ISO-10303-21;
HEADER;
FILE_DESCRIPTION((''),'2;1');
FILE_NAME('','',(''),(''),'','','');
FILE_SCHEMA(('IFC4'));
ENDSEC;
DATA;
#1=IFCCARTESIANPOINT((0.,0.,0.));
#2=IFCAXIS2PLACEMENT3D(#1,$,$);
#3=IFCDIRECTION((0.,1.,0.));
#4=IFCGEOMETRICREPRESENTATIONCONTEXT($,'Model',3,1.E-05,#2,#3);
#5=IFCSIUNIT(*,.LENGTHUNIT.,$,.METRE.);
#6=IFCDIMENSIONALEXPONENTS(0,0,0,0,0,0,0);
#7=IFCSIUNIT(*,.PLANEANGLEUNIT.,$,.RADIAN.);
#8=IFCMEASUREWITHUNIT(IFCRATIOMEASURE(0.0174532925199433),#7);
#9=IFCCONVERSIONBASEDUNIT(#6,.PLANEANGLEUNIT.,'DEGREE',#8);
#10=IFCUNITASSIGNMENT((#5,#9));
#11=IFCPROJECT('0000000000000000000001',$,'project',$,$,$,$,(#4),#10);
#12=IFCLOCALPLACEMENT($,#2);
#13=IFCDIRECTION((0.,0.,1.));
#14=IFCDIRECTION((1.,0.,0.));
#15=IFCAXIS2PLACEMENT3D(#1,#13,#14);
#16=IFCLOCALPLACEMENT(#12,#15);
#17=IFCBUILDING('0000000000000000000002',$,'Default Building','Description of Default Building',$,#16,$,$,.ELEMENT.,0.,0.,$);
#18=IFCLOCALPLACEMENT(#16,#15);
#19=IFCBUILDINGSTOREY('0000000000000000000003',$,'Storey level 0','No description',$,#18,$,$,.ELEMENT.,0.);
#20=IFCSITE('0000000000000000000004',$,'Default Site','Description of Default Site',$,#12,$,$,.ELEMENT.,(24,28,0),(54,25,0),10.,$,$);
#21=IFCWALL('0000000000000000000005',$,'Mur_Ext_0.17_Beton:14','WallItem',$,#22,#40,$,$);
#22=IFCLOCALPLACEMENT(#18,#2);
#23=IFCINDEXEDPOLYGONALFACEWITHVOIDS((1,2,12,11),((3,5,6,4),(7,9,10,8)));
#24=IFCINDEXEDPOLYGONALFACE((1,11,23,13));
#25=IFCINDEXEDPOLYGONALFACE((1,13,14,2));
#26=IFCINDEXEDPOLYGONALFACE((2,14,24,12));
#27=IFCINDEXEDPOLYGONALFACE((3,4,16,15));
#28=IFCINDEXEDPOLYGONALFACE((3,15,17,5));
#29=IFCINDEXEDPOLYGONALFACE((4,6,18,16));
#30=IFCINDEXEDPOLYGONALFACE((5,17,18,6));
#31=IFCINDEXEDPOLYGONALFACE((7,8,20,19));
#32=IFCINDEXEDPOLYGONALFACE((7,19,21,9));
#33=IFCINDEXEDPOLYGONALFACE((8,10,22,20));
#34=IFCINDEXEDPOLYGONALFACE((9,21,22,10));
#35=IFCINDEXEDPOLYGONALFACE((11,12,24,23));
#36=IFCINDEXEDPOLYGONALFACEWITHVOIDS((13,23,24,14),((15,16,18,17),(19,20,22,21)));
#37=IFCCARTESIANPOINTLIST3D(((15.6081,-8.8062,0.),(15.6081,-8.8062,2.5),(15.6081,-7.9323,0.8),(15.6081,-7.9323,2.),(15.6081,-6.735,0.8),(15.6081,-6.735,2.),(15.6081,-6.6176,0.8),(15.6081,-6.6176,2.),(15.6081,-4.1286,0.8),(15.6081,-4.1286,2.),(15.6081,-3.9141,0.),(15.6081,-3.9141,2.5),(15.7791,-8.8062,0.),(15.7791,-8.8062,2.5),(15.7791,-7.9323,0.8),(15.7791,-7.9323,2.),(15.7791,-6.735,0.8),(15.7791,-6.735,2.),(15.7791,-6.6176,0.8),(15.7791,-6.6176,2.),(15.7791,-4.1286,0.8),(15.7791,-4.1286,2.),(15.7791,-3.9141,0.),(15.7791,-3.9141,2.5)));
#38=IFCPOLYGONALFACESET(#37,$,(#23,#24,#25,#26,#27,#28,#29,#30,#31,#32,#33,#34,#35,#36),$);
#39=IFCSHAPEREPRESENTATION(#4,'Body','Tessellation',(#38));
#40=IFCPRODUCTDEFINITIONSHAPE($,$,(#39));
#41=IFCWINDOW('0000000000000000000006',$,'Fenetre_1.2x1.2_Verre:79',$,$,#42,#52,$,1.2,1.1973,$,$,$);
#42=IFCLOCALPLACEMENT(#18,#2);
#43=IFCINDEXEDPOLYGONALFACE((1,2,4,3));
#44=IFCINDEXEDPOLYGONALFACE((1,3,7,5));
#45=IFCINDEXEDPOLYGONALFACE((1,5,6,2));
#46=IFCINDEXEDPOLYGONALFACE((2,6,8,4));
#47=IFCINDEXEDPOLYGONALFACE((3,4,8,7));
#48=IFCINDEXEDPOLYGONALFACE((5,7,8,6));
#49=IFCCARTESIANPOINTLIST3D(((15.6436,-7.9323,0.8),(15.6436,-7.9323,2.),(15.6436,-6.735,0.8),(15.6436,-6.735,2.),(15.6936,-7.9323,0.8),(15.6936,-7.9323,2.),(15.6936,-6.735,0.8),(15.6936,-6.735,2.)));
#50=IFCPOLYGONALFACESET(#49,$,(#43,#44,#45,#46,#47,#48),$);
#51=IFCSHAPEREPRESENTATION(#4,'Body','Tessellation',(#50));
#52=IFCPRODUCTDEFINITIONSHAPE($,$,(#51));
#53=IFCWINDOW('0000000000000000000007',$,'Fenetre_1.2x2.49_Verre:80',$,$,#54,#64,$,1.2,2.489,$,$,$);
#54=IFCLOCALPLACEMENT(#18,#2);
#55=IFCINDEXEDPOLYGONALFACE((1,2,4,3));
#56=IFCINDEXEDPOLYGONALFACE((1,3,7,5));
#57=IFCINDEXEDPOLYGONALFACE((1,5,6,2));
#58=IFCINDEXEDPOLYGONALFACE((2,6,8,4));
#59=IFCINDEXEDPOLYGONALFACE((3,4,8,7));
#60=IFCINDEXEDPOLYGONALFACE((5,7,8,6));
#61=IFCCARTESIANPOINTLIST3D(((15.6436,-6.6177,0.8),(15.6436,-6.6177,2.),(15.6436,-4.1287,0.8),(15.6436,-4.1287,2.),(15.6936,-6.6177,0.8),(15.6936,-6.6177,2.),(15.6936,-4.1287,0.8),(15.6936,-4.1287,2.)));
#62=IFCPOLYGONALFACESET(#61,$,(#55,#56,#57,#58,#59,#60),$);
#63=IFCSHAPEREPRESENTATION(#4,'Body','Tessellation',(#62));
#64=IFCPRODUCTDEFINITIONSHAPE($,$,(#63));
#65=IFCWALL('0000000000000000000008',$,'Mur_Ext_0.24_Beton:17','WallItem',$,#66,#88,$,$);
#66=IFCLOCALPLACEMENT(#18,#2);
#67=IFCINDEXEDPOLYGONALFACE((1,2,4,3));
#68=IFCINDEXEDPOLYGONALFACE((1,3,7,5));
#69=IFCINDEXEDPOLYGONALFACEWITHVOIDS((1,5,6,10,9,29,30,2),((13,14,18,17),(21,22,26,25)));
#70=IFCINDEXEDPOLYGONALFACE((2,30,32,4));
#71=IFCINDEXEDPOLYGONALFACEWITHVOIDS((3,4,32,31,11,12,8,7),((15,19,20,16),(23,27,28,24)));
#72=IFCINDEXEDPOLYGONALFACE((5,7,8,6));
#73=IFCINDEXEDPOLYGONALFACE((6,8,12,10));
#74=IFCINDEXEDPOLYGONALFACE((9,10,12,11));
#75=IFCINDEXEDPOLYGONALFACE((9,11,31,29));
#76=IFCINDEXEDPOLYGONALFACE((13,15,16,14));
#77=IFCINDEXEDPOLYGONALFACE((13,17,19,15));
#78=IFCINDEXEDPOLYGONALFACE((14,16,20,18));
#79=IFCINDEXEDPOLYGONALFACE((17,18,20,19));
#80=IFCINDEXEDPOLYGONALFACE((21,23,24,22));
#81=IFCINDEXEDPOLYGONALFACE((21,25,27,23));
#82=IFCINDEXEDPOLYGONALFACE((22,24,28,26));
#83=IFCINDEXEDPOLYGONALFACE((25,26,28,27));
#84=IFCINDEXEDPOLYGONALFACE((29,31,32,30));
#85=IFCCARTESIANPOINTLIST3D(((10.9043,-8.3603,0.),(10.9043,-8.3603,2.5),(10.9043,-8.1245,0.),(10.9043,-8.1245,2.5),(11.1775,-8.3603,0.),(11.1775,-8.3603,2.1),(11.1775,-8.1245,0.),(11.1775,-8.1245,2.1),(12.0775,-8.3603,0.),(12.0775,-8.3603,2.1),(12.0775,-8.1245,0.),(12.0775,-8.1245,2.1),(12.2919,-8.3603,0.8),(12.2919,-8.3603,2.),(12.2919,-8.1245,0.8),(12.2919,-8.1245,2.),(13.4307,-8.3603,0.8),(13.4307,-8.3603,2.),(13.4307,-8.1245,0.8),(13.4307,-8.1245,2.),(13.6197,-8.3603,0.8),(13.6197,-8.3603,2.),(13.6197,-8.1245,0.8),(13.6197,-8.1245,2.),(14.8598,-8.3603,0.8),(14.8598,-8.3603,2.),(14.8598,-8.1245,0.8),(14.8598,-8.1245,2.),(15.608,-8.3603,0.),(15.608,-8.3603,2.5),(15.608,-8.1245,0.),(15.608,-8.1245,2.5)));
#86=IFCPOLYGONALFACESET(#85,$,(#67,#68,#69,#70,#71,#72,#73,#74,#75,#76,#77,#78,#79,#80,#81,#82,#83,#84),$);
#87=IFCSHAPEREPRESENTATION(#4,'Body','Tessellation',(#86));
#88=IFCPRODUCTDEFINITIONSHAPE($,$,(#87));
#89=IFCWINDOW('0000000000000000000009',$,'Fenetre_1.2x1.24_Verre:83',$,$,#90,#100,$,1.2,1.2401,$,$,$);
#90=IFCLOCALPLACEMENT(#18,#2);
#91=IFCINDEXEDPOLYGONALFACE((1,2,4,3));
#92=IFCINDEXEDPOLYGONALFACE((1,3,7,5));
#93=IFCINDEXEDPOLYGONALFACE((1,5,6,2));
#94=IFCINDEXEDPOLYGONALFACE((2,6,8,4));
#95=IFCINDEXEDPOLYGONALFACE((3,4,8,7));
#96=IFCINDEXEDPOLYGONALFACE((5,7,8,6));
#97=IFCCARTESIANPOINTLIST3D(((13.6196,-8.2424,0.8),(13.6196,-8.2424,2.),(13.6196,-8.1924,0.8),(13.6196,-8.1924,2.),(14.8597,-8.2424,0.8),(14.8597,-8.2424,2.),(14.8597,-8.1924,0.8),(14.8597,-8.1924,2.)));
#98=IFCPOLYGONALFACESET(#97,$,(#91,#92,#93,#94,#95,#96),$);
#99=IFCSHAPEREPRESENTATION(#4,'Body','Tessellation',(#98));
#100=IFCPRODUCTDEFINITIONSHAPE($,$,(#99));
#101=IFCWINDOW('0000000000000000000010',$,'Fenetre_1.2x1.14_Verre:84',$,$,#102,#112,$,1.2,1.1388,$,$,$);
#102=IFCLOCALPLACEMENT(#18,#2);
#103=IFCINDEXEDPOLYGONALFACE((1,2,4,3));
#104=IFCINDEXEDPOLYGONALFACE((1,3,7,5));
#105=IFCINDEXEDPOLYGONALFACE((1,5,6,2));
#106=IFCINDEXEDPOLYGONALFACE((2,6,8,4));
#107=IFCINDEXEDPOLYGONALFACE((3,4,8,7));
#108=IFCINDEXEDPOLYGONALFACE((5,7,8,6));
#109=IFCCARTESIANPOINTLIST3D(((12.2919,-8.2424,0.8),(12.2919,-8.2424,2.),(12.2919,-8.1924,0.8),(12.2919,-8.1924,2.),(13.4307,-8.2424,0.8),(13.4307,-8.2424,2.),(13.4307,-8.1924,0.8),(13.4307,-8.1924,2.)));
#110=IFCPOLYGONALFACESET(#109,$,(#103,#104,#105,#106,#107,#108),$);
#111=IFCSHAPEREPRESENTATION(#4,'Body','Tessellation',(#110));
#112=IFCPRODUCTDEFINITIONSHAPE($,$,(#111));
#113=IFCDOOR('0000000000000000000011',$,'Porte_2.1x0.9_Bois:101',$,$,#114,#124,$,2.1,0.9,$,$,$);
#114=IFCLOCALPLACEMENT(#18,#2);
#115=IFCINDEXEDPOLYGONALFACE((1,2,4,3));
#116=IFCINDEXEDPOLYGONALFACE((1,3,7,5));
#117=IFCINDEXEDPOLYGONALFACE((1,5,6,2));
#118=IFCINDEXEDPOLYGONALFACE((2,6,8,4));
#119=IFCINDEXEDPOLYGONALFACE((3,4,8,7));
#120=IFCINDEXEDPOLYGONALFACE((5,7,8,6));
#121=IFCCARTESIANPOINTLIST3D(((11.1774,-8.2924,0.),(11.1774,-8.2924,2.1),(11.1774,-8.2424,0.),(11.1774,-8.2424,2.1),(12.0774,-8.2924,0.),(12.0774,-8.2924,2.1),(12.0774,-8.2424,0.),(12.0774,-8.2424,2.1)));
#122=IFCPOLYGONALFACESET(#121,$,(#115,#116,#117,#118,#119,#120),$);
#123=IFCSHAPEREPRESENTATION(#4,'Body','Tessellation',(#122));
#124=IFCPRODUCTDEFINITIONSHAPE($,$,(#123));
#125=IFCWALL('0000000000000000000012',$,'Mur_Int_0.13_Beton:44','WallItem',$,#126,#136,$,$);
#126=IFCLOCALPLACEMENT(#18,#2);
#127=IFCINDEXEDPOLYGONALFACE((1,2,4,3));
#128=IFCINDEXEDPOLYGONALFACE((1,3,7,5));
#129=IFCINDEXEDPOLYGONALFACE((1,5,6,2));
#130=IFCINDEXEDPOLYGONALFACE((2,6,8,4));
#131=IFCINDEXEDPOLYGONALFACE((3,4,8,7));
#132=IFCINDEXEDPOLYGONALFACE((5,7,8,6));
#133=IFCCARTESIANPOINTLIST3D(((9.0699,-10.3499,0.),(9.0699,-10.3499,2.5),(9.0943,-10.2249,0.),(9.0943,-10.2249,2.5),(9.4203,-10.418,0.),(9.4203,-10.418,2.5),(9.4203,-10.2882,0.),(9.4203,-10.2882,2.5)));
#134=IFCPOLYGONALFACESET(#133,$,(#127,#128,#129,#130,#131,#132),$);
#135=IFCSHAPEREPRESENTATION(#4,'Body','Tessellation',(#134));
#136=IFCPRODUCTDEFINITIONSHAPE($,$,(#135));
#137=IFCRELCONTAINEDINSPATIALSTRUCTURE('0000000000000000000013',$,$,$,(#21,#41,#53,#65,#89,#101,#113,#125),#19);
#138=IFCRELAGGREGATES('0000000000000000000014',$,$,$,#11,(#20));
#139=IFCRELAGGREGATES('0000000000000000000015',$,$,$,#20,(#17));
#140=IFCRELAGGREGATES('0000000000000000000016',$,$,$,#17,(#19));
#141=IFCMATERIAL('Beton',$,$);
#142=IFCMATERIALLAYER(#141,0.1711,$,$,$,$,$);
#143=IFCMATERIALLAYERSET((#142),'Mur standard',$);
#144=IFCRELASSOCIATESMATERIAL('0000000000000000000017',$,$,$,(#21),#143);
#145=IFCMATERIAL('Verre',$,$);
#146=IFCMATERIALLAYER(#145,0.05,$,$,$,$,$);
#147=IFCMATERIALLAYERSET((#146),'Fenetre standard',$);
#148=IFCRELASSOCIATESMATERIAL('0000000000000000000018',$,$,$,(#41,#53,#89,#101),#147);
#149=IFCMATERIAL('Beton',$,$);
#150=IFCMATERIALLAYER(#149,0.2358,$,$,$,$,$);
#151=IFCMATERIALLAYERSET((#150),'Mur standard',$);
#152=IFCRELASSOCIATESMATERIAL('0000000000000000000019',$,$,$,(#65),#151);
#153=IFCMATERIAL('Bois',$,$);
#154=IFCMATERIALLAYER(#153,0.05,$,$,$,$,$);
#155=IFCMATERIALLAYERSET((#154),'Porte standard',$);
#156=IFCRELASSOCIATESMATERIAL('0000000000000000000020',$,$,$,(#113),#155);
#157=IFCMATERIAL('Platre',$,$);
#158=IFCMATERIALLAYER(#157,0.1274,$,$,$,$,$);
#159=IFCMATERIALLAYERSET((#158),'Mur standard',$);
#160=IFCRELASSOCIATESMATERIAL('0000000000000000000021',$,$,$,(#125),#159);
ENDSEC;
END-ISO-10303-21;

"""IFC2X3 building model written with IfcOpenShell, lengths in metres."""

from ifc_helpers import new_model, entity, si_unit, converted_unit, direction, frame, origin, origin_with_axes, place, context, project, spatial, polyline, outline, extrude, material, layer, layer_set, layer_usage, element, fill, save


model = new_model("IFC2X3")

# Units and contexts
model_context = context("Model", 3, precision=1e-05, world=origin(), true_north=direction((0.0, 1.0, 0.0)))
ifc_project = project(units=[si_unit("LENGTHUNIT", "METRE"), converted_unit("PLANEANGLEUNIT", "DEGREE", entity("IfcRatioMeasure", 0.0174532925199433), si_unit("PLANEANGLEUNIT", "RADIAN"), dimensions=[0, 0, 0, 0, 0, 0, 0])], contexts=[model_context])

# Site, building, storey
site_placement = place(None, origin())
site = spatial("IfcSite", under=ifc_project, at=site_placement, Name="Default Site", Description="Description of Default Site", CompositionType="ELEMENT", RefLatitude=(24, 28, 0), RefLongitude=(54, 25, 0), RefElevation=10.0)
building_placement = place(site_placement, origin_with_axes())
building = spatial("IfcBuilding", under=site, at=building_placement, Name="Default Building", Description="Description of Default Building", CompositionType="ELEMENT", ElevationOfRefHeight=0.0, ElevationOfTerrain=0.0)
storey_placement = place(building_placement, origin_with_axes())
storey = spatial("IfcBuildingStorey", under=building, at=storey_placement, Name="Storey level 0", Description="No description", CompositionType="ELEMENT", Elevation=0.0)

# Shared definitions
ifc_material_1 = material(Name="Verre")
ifc_layer_1 = layer(ifc_material_1, 0.05)
ifc_layer_set_1 = layer_set([ifc_layer_1], Name="Fenetre standard")
ifc_layer_usage_1 = layer_usage(ifc_layer_set_1, "AXIS2", "NEGATIVE", 0.05)
ifc_material_2 = material(Name="Bois")
ifc_layer_2 = layer(ifc_material_2, 0.05)
ifc_layer_set_2 = layer_set([ifc_layer_2], Name="Porte standard")
ifc_layer_usage_2 = layer_usage(ifc_layer_set_2, "AXIS2", "NEGATIVE", 0.05)

# Wall, openings, windows
ifc_material_3 = material(Name="Beton")
ifc_layer_3 = layer(ifc_material_3, 0.1711)
ifc_layer_set_3 = layer_set([ifc_layer_3], Name="Mur standard")
ifc_layer_usage_3 = layer_usage(ifc_layer_set_3, "AXIS2", "NEGATIVE", 0.1711)
wall_1_placement = place(storey_placement, frame((15.6936, -3.9141, 0.0), z_axis=(0.0, 0.0, 1.0), x_axis=(0.0, -1.0, 0.0)))
wall_1 = element("IfcWall", 1, at=wall_1_placement, inside=storey, material=ifc_layer_usage_3, Name="Mur_Ext_0.17_Beton:14", Description="WallItem", context=model_context, shape_type="SweptSolid", body=[
    extrude(outline(polyline([(0.0, -0.0855), (4.8921, -0.0855), (4.8921, 0.0855), (0.0, 0.0855), (0.0, -0.0855)])), origin(), (0.0, 0.0, 1.0), 2.5),
])
opening_1_placement = place(storey_placement, frame((15.6081, -6.735, 0.8), z_axis=(0.0, 0.0, 1.0), x_axis=(0.0, -1.0, 0.0)))
opening_1 = element("IfcOpeningElement", 2, at=opening_1_placement, cuts=wall_1, context=model_context, shape_type="SweptSolid", body=[
    extrude(outline(polyline([(0.0, -0.05), (1.1973, -0.05), (1.1973, 0.2211), (0.0, 0.2211), (0.0, -0.05)])), origin(), (0.0, 0.0, 1.0), 1.2),
])
opening_2_placement = place(storey_placement, frame((15.6081, -4.1286, 0.8), z_axis=(0.0, 0.0, 1.0), x_axis=(0.0, -1.0, 0.0)))
opening_2 = element("IfcOpeningElement", 3, at=opening_2_placement, cuts=wall_1, context=model_context, shape_type="SweptSolid", body=[
    extrude(outline(polyline([(0.0, -0.05), (2.489, -0.05), (2.489, 0.2211), (0.0, 0.2211), (0.0, -0.05)])), origin(), (0.0, 0.0, 1.0), 1.2),
])
window_1_placement = place(wall_1_placement, frame((2.8209, 0.0, 0.8), z_axis=(0.0, 0.0, 1.0), x_axis=(1.0, 0.0, 0.0)))
window_1 = element("IfcWindow", 4, at=window_1_placement, inside=storey, material=ifc_layer_usage_1, Name="Fenetre_1.2x1.2_Verre:79", OverallHeight=1.2, OverallWidth=1.1973, context=model_context, shape_type="SweptSolid", body=[
    extrude(outline(polyline([(0.0, 0.0), (1.1973, 0.0), (1.1973, -0.05), (0.0, -0.05), (0.0, 0.0)])), origin(), (0.0, 0.0, 1.0), 1.2),
])
fill(opening_1, window_1)
window_2_placement = place(wall_1_placement, frame((0.2146, 0.0, 0.8), z_axis=(0.0, 0.0, 1.0), x_axis=(1.0, 0.0, 0.0)))
window_2 = element("IfcWindow", 5, at=window_2_placement, inside=storey, material=ifc_layer_usage_1, Name="Fenetre_1.2x2.49_Verre:80", OverallHeight=1.2, OverallWidth=2.489, context=model_context, shape_type="SweptSolid", body=[
    extrude(outline(polyline([(0.0, 0.0), (2.489, 0.0), (2.489, -0.05), (0.0, -0.05), (0.0, 0.0)])), origin(), (0.0, 0.0, 1.0), 1.2),
])
fill(opening_2, window_2)

# Wall, openings, windows, door
ifc_material_4 = material(Name="Beton")
ifc_layer_4 = layer(ifc_material_4, 0.2358)
ifc_layer_set_4 = layer_set([ifc_layer_4], Name="Mur standard")
ifc_layer_usage_4 = layer_usage(ifc_layer_set_4, "AXIS2", "NEGATIVE", 0.2358)
wall_2_placement = place(storey_placement, frame((10.8963, -8.2424, 0.0), z_axis=(0.0, 0.0, 1.0), x_axis=(1.0, 0.0, 0.0)))
wall_2 = element("IfcWall", 6, at=wall_2_placement, inside=storey, material=ifc_layer_usage_4, Name="Mur_Ext_0.24_Beton:17", Description="WallItem", context=model_context, shape_type="SweptSolid", body=[
    extrude(outline(polyline([(0.008, 0.1179), (0.008, -0.1179), (4.7117, -0.1179), (4.7117, 0.1179), (0.008, 0.1179)])), origin(), (0.0, 0.0, 1.0), 2.5),
])
opening_3_placement = place(storey_placement, frame((14.8598, -8.1245, 0.8), z_axis=(0.0, 0.0, 1.0), x_axis=(-1.0, 0.0, 0.0)))
opening_3 = element("IfcOpeningElement", 7, at=opening_3_placement, cuts=wall_2, context=model_context, shape_type="SweptSolid", body=[
    extrude(outline(polyline([(1.2401, 0.2858), (0.0, 0.2858), (0.0, -0.05), (1.2401, -0.05), (1.2401, 0.2858)])), origin(), (0.0, 0.0, 1.0), 1.2),
])
opening_4_placement = place(storey_placement, frame((13.4307, -8.1245, 0.8), z_axis=(0.0, 0.0, 1.0), x_axis=(-1.0, 0.0, 0.0)))
opening_4 = element("IfcOpeningElement", 8, at=opening_4_placement, cuts=wall_2, context=model_context, shape_type="SweptSolid", body=[
    extrude(outline(polyline([(1.1388, 0.2858), (0.0, 0.2858), (0.0, -0.05), (1.1388, -0.05), (1.1388, 0.2858)])), origin(), (0.0, 0.0, 1.0), 1.2),
])
opening_5_placement = place(storey_placement, frame((11.1775, -8.1245, 0.0), z_axis=(0.0, 0.0, 1.0), x_axis=(1.0, 0.0, 0.0)))
opening_5 = element("IfcOpeningElement", 9, at=opening_5_placement, cuts=wall_2, context=model_context, shape_type="SweptSolid", body=[
    extrude(outline(polyline([(0.0, -0.2858), (0.9, -0.2858), (0.9, 0.05), (0.0, 0.05), (0.0, -0.2858)])), origin(), (0.0, 0.0, 1.0), 2.1),
])
window_3_placement = place(wall_2_placement, frame((3.9634, 0.0, 0.8), z_axis=(0.0, 0.0, 1.0), x_axis=(-1.0, 0.0, 0.0)))
window_3 = element("IfcWindow", 10, at=window_3_placement, inside=storey, material=ifc_layer_usage_1, Name="Fenetre_1.2x1.24_Verre:83", OverallHeight=1.2, OverallWidth=1.2401, context=model_context, shape_type="SweptSolid", body=[
    extrude(outline(polyline([(0.0, 0.0), (1.2401, 0.0), (1.2401, -0.05), (0.0, -0.05), (0.0, 0.0)])), origin(), (0.0, 0.0, 1.0), 1.2),
])
fill(opening_3, window_3)
window_4_placement = place(wall_2_placement, frame((2.5344, 0.0, 0.8), z_axis=(0.0, 0.0, 1.0), x_axis=(-1.0, 0.0, 0.0)))
window_4 = element("IfcWindow", 11, at=window_4_placement, inside=storey, material=ifc_layer_usage_1, Name="Fenetre_1.2x1.14_Verre:84", OverallHeight=1.2, OverallWidth=1.1388, context=model_context, shape_type="SweptSolid", body=[
    extrude(outline(polyline([(0.0, 0.0), (1.1388, 0.0), (1.1388, -0.05), (0.0, -0.05), (0.0, 0.0)])), origin(), (0.0, 0.0, 1.0), 1.2),
])
fill(opening_4, window_4)
door_1_placement = place(wall_2_placement, frame((0.2811, 0.0, 0.0), z_axis=(0.0, 0.0, 1.0), x_axis=(1.0, 0.0, 0.0)))
door_1 = element("IfcDoor", 12, at=door_1_placement, inside=storey, material=ifc_layer_usage_2, Name="Porte_2.1x0.9_Bois:101", OverallHeight=2.1, OverallWidth=0.9, context=model_context, shape_type="SweptSolid", body=[
    extrude(outline(polyline([(0.0, 0.0), (0.9, 0.0), (0.9, -0.05), (0.0, -0.05), (0.0, 0.0)])), origin(), (0.0, 0.0, 1.0), 2.1),
])
fill(opening_5, door_1)

# Wall
ifc_material_5 = material(Name="Platre")
ifc_layer_5 = layer(ifc_material_5, 0.1274)
ifc_layer_set_5 = layer_set([ifc_layer_5], Name="Mur standard")
ifc_layer_usage_5 = layer_usage(ifc_layer_set_5, "AXIS2", "NEGATIVE", 0.1274)
wall_3_placement = place(storey_placement, frame((9.0821, -10.2874, 0.0), z_axis=(0.0, 0.0, 1.0), x_axis=(0.9816, -0.1908, 0.0)))
element("IfcWall", 13, at=wall_3_placement, inside=storey, material=ifc_layer_usage_5, Name="Mur_Int_0.13_Beton:44", Description="WallItem", context=model_context, shape_type="SweptSolid", body=[
    extrude(outline(polyline([(0.0, 0.0637), (0.0, -0.0637), (0.3569, -0.0637), (0.3321, 0.0637), (0.0, 0.0637)])), origin(), (0.0, 0.0, 1.0), 2.5),
])

save(model, "model.ifc")
